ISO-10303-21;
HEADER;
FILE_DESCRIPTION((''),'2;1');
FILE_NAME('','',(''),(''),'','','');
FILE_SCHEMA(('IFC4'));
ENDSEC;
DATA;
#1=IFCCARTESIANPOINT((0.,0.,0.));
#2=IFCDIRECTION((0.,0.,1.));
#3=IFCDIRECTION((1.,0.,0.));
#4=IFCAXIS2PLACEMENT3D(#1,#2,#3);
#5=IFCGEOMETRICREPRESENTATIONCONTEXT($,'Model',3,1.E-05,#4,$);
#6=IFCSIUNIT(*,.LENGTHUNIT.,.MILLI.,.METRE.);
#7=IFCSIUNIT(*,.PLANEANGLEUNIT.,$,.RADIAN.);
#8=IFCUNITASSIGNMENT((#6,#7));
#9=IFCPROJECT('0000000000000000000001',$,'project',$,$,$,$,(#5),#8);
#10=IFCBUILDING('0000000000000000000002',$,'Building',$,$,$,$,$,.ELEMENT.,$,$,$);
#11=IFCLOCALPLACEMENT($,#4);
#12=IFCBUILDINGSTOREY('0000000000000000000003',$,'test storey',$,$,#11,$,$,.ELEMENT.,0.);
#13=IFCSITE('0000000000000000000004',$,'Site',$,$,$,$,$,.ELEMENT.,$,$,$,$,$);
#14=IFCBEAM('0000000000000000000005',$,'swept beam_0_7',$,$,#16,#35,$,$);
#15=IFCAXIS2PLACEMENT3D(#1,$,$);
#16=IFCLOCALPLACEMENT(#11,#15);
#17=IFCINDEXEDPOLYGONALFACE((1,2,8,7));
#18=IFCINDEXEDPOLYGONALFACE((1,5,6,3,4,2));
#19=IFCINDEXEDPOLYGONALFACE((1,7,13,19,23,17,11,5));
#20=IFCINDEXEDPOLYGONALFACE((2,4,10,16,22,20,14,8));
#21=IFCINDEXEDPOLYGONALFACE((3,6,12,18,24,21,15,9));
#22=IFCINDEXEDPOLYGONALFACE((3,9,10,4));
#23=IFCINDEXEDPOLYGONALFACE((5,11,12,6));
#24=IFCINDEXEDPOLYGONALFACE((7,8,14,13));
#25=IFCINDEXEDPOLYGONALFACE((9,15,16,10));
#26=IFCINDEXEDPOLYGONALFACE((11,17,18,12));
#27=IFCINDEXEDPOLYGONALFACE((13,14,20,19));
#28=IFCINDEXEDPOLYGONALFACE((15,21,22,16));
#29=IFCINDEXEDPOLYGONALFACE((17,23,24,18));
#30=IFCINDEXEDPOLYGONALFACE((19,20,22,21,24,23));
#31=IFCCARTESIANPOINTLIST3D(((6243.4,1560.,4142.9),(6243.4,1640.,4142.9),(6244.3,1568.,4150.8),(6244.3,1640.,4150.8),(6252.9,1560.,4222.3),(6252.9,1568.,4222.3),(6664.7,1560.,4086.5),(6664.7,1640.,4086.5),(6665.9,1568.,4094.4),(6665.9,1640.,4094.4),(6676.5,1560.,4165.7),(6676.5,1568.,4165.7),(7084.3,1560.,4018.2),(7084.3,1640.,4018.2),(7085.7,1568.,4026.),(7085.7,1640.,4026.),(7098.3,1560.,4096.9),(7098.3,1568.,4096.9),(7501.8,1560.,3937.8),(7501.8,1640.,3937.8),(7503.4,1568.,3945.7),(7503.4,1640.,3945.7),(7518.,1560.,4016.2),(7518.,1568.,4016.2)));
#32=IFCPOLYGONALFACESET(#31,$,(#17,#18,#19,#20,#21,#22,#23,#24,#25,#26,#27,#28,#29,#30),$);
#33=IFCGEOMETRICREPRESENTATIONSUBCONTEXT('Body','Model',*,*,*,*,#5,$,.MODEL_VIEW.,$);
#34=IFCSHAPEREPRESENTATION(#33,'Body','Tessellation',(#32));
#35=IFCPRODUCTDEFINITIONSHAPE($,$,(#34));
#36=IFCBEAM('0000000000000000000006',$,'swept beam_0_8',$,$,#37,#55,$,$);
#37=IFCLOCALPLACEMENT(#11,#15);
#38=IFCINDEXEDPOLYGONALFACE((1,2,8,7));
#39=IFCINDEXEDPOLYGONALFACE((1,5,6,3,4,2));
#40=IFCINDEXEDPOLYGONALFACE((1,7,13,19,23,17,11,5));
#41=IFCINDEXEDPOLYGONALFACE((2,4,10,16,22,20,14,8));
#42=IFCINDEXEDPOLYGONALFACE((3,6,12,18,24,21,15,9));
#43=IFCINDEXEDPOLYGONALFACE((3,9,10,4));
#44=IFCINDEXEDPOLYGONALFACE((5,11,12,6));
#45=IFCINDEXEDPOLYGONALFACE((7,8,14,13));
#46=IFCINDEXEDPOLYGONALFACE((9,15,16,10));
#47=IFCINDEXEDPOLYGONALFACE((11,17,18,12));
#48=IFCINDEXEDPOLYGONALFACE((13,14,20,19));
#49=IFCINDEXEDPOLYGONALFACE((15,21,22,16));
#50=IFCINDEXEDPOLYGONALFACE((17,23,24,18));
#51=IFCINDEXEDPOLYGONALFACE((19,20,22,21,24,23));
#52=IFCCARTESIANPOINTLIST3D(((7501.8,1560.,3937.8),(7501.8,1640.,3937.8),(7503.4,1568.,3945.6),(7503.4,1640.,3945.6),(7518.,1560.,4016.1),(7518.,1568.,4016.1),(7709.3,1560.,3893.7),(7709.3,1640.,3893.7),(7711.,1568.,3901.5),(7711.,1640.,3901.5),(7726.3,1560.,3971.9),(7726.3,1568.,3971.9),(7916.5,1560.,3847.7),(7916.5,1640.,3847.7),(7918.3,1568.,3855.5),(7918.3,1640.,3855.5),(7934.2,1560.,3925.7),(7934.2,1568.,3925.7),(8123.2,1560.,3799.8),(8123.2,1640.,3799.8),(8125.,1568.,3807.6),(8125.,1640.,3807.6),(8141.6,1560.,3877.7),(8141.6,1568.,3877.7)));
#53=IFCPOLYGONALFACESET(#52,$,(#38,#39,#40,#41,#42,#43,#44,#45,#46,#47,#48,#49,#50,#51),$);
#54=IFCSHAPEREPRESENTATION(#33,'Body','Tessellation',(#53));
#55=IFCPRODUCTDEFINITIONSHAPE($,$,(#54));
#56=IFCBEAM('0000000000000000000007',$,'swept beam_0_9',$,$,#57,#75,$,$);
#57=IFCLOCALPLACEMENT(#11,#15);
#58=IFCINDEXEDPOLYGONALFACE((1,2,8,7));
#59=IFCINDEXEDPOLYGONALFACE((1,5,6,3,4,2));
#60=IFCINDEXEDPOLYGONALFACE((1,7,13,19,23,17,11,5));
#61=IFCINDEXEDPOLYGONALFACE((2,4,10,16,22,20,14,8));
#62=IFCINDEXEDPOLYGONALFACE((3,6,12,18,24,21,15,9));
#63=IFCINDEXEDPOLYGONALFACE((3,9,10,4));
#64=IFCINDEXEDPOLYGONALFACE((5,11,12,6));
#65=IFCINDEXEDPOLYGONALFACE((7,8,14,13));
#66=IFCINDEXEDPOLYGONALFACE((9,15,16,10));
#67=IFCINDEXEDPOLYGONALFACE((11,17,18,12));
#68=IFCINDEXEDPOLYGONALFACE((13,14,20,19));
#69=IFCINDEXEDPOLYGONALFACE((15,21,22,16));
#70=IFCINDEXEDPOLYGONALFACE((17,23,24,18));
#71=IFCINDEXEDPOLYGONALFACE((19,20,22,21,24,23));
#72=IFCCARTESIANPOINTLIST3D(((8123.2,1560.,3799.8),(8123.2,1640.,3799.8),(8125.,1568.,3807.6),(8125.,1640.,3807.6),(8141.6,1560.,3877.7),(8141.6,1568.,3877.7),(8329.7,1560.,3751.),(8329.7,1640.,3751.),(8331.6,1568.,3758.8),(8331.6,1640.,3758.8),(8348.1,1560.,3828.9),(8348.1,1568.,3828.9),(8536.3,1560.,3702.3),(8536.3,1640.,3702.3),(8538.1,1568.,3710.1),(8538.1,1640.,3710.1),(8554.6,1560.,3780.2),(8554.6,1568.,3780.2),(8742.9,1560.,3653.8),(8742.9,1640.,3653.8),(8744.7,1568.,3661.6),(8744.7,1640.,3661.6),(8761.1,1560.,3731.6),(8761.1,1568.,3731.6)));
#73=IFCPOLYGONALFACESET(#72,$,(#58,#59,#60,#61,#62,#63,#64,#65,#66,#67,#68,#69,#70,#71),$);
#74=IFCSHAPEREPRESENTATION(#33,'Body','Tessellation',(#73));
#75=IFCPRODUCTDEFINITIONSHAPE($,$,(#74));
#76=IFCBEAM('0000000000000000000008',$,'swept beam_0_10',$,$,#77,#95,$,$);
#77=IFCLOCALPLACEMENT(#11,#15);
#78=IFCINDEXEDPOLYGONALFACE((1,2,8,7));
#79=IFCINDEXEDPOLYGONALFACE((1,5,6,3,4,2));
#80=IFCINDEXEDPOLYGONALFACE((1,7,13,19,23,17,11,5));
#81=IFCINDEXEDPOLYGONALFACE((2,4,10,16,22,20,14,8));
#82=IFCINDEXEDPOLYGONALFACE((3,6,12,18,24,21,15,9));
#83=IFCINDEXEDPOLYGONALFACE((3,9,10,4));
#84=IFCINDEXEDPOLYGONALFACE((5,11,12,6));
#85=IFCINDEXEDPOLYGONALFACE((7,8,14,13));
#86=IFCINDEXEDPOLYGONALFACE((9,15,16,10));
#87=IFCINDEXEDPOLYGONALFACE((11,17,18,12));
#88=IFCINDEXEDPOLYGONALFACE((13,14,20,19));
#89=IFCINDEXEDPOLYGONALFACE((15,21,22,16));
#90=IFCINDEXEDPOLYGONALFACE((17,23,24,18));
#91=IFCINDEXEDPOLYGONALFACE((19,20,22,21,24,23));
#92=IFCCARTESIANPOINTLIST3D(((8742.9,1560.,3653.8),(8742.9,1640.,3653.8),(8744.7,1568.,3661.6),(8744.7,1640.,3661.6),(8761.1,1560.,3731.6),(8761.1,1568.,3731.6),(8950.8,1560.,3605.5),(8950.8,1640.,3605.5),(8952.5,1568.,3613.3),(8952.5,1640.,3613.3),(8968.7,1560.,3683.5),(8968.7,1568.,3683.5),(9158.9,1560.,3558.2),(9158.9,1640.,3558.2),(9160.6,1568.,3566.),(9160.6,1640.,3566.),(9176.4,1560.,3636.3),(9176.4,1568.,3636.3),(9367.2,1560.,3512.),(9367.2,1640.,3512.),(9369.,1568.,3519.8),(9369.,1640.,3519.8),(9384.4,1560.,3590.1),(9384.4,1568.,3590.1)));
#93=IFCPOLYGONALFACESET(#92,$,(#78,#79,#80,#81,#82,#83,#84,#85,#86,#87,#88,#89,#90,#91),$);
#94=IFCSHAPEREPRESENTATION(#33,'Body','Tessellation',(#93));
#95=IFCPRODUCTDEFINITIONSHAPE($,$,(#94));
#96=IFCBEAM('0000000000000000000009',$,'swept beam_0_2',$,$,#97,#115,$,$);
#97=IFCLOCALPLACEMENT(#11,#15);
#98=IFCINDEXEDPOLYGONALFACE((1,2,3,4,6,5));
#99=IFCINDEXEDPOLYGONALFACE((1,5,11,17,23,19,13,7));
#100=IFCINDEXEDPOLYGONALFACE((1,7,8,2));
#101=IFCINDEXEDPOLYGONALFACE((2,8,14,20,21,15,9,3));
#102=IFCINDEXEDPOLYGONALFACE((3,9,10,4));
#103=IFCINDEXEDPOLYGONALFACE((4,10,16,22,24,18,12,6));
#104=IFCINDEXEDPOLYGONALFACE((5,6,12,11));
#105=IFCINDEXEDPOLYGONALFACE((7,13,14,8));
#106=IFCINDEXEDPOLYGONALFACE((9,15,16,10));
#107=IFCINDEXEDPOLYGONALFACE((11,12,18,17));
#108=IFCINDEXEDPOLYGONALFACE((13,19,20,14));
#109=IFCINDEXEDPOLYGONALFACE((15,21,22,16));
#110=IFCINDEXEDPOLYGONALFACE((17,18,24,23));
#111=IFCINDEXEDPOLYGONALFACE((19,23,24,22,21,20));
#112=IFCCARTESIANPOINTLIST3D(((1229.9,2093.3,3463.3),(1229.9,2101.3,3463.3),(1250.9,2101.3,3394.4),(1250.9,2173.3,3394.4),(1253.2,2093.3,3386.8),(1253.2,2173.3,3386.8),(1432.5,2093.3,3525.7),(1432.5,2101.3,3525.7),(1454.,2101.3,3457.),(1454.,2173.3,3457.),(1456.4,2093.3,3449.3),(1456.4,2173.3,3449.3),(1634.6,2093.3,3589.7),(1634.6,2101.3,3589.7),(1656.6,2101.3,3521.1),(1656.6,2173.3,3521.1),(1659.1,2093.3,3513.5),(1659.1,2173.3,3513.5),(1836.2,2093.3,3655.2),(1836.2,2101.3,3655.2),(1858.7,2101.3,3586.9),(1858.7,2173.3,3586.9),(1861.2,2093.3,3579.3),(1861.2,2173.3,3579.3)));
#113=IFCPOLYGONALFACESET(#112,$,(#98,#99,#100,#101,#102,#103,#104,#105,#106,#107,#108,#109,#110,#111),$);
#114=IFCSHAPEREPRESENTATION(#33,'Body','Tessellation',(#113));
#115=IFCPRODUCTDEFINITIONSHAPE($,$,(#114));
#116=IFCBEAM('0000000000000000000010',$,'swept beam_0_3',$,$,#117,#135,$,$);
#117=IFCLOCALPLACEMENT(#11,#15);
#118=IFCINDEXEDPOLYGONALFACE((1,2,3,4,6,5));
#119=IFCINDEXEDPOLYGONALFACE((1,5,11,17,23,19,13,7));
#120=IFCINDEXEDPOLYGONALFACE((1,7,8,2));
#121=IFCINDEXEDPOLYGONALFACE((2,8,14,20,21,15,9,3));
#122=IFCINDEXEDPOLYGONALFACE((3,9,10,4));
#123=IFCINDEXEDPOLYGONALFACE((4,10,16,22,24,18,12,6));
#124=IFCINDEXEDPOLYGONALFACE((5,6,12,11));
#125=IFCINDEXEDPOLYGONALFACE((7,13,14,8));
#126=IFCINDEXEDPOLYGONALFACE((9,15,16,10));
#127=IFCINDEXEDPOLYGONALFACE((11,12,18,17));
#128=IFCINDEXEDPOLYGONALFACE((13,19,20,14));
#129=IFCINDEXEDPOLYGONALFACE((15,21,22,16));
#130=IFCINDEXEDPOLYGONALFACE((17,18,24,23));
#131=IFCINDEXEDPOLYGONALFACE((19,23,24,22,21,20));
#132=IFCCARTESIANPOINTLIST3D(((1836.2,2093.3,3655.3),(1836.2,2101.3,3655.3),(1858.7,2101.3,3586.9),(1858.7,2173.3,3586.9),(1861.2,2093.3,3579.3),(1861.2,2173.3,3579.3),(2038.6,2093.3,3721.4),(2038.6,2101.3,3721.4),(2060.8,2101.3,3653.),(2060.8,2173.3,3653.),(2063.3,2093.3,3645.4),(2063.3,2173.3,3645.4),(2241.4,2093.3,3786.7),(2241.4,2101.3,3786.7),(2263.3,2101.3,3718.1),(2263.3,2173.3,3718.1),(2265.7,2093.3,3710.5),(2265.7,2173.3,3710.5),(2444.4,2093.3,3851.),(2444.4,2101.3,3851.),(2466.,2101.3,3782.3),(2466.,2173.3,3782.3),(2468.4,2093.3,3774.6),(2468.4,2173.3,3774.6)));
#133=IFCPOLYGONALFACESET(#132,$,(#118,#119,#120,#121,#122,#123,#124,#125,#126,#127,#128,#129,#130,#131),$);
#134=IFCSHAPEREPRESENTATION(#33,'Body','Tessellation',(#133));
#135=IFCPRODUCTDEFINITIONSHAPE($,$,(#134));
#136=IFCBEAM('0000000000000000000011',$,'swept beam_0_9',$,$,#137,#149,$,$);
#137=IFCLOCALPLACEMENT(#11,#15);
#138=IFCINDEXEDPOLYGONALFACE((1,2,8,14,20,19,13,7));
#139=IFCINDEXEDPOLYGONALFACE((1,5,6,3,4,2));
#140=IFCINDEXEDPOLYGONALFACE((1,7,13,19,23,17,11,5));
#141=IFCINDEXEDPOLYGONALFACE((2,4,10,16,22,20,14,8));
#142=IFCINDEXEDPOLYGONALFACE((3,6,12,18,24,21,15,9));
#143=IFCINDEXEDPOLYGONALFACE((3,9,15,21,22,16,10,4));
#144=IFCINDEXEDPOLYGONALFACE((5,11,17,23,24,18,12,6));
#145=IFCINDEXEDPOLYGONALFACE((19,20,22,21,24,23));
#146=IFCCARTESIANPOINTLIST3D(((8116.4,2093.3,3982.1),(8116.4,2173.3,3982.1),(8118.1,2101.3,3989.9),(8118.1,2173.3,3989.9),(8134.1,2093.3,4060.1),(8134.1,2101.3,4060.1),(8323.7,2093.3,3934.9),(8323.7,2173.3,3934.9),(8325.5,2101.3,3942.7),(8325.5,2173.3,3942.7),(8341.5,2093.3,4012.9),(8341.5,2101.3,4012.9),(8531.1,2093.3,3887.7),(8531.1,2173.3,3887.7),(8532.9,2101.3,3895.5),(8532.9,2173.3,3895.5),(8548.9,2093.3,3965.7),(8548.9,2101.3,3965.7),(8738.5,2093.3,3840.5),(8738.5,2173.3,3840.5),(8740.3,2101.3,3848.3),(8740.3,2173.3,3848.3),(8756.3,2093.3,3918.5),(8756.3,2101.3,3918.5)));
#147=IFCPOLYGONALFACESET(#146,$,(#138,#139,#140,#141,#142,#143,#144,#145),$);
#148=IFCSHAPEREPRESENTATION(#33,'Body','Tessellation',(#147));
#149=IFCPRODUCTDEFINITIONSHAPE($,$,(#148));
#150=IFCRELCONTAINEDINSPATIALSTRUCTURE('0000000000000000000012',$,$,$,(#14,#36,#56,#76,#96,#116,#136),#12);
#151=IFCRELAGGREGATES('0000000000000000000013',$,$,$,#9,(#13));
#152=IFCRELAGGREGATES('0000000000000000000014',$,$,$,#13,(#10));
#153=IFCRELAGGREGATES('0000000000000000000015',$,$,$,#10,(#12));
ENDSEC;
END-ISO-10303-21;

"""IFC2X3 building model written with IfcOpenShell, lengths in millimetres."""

from ifc_helpers import new_model, entity, si_unit, origin_with_axes, place, context, subcontext, project, spatial, element, save


model = new_model("IFC2X3")

# Units and contexts
model_context = context("Model", 3, precision=1e-05, world=origin_with_axes())
body_context = subcontext(model_context, "Body", "Model", "MODEL_VIEW")
ifc_project = project(units=[si_unit("LENGTHUNIT", "METRE", prefix="MILLI"), si_unit("PLANEANGLEUNIT", "RADIAN")], contexts=[model_context])

# Site, building, storey
site = spatial("IfcSite", under=ifc_project, Name="Site", CompositionType="ELEMENT")
building = spatial("IfcBuilding", under=site, Name="Building", CompositionType="ELEMENT")
storey_placement = place(None, origin_with_axes())
storey = spatial("IfcBuildingStorey", under=building, at=storey_placement, Name="test storey", CompositionType="ELEMENT", Elevation=0.0)

# Beams
beam_1_placement = place(storey_placement, origin_with_axes())
element("IfcBeam", 1, at=beam_1_placement, inside=storey, Name="swept beam_0_7", context=body_context, shape_type="SweptSolid", body=[
    entity("IfcRevolvedAreaSolid", entity("IfcArbitraryClosedProfileDef", "AREA", None, entity("IfcPolyline", [entity("IfcCartesianPoint", [80.0, -40.0]), entity("IfcCartesianPoint", [80.0, -32.0]), entity("IfcCartesianPoint", [8.0, -32.0]), entity("IfcCartesianPoint", [8.0, 40.0]), entity("IfcCartesianPoint", [0.0, 40.0]), entity("IfcCartesianPoint", [0.0, -40.0]), entity("IfcCartesianPoint", [80.0, -40.0])])), entity("IfcAxis2Placement3D", entity("IfcCartesianPoint", [6243.4, 1600.0, 4142.9]), entity("IfcDirection", [-0.993, 0.0, 0.1183]), entity("IfcDirection", [0.1183, 0.0, 0.993])), entity("IfcAxis1Placement", entity("IfcCartesianPoint", [-14849.0, 0.0, 0.0]), entity("IfcDirection", [0.0, 1.0, 0.0])), 0.085889),
])
beam_2_placement = place(storey_placement, origin_with_axes())
element("IfcBeam", 2, at=beam_2_placement, inside=storey, Name="swept beam_0_8", context=body_context, shape_type="SweptSolid", body=[
    entity("IfcRevolvedAreaSolid", entity("IfcArbitraryClosedProfileDef", "AREA", None, entity("IfcPolyline", [entity("IfcCartesianPoint", [80.0, -40.0]), entity("IfcCartesianPoint", [80.0, -32.0]), entity("IfcCartesianPoint", [8.0, -32.0]), entity("IfcCartesianPoint", [8.0, 40.0]), entity("IfcCartesianPoint", [0.0, 40.0]), entity("IfcCartesianPoint", [0.0, -40.0]), entity("IfcCartesianPoint", [80.0, -40.0])])), entity("IfcAxis2Placement3D", entity("IfcCartesianPoint", [7501.8, 1600.0, 3937.8]), entity("IfcDirection", [-0.9792, 0.0, 0.2031]), entity("IfcDirection", [0.2031, 0.0, 0.9792])), entity("IfcAxis1Placement", entity("IfcCartesianPoint", [-22828.3, 0.0, 0.0]), entity("IfcDirection", [0.0, 1.0, 0.0])), 0.027886),
])
beam_3_placement = place(storey_placement, origin_with_axes())
element("IfcBeam", 3, at=beam_3_placement, inside=storey, Name="swept beam_0_9", context=body_context, shape_type="SweptSolid", body=[
    entity("IfcRevolvedAreaSolid", entity("IfcArbitraryClosedProfileDef", "AREA", None, entity("IfcPolyline", [entity("IfcCartesianPoint", [-80.0, 40.0]), entity("IfcCartesianPoint", [-80.0, 32.0]), entity("IfcCartesianPoint", [-8.0, 32.0]), entity("IfcCartesianPoint", [-8.0, -40.0]), entity("IfcCartesianPoint", [0.0, -40.0]), entity("IfcCartesianPoint", [0.0, 40.0]), entity("IfcCartesianPoint", [-80.0, 40.0])])), entity("IfcAxis2Placement3D", entity("IfcCartesianPoint", [8123.2, 1600.0, 3799.8]), entity("IfcDirection", [-0.9731, 0.0, 0.2303]), entity("IfcDirection", [-0.2303, 0.0, -0.9731])), entity("IfcAxis1Placement", entity("IfcCartesianPoint", [-346113.7, 0.0, 0.0]), entity("IfcDirection", [0.0, 1.0, 0.0])), 0.001839),
])
beam_4_placement = place(storey_placement, origin_with_axes())
element("IfcBeam", 4, at=beam_4_placement, inside=storey, Name="swept beam_0_10", context=body_context, shape_type="SweptSolid", body=[
    entity("IfcRevolvedAreaSolid", entity("IfcArbitraryClosedProfileDef", "AREA", None, entity("IfcPolyline", [entity("IfcCartesianPoint", [-80.0, 40.0]), entity("IfcCartesianPoint", [-80.0, 32.0]), entity("IfcCartesianPoint", [-8.0, 32.0]), entity("IfcCartesianPoint", [-8.0, -40.0]), entity("IfcCartesianPoint", [0.0, -40.0]), entity("IfcCartesianPoint", [0.0, 40.0]), entity("IfcCartesianPoint", [-80.0, 40.0])])), entity("IfcAxis2Placement3D", entity("IfcCartesianPoint", [8742.9, 1600.0, 3653.8]), entity("IfcDirection", [-0.9735, 0.0, 0.2285]), entity("IfcDirection", [-0.2285, 0.0, -0.9735])), entity("IfcAxis1Placement", entity("IfcCartesianPoint", [-44317.9, 0.0, 0.0]), entity("IfcDirection", [0.0, 1.0, 0.0])), 0.014448),
])
beam_5_placement = place(storey_placement, origin_with_axes())
element("IfcBeam", 5, at=beam_5_placement, inside=storey, Name="swept beam_0_2", context=body_context, shape_type="SweptSolid", body=[
    entity("IfcRevolvedAreaSolid", entity("IfcArbitraryClosedProfileDef", "AREA", None, entity("IfcPolyline", [entity("IfcCartesianPoint", [-80.0, 40.0]), entity("IfcCartesianPoint", [-80.0, 32.0]), entity("IfcCartesianPoint", [-8.0, 32.0]), entity("IfcCartesianPoint", [-8.0, -40.0]), entity("IfcCartesianPoint", [0.0, -40.0]), entity("IfcCartesianPoint", [0.0, 40.0]), entity("IfcCartesianPoint", [-80.0, 40.0])])), entity("IfcAxis2Placement3D", entity("IfcCartesianPoint", [1253.2, 2133.3, 3386.8]), entity("IfcDirection", [-0.9568, 0.0, -0.2906]), entity("IfcDirection", [0.2906, 0.0, -0.9568])), entity("IfcAxis1Placement", entity("IfcCartesianPoint", [-27170.3, 0.0, 0.0]), entity("IfcDirection", [0.0, 1.0, 0.0])), 0.023474),
])
beam_6_placement = place(storey_placement, origin_with_axes())
element("IfcBeam", 6, at=beam_6_placement, inside=storey, Name="swept beam_0_3", context=body_context, shape_type="SweptSolid", body=[
    entity("IfcRevolvedAreaSolid", entity("IfcArbitraryClosedProfileDef", "AREA", None, entity("IfcPolyline", [entity("IfcCartesianPoint", [80.0, -40.0]), entity("IfcCartesianPoint", [80.0, -32.0]), entity("IfcCartesianPoint", [8.0, -32.0]), entity("IfcCartesianPoint", [8.0, 40.0]), entity("IfcCartesianPoint", [0.0, 40.0]), entity("IfcCartesianPoint", [0.0, -40.0]), entity("IfcCartesianPoint", [80.0, -40.0])])), entity("IfcAxis2Placement3D", entity("IfcCartesianPoint", [1861.2, 2133.3, 3579.3]), entity("IfcDirection", [-0.9497, 0.0, -0.313]), entity("IfcDirection", [-0.313, 0.0, 0.9497])), entity("IfcAxis1Placement", entity("IfcCartesianPoint", [-44978.1, 0.0, 0.0]), entity("IfcDirection", [0.0, 1.0, 0.0])), 0.014181),
])
beam_7_placement = place(storey_placement, origin_with_axes())
element("IfcBeam", 7, at=beam_7_placement, inside=storey, Name="swept beam_0_9", context=body_context, shape_type="SweptSolid", body=[
    entity("IfcRevolvedAreaSolid", entity("IfcArbitraryClosedProfileDef", "AREA", None, entity("IfcPolyline", [entity("IfcCartesianPoint", [-80.0, 40.0]), entity("IfcCartesianPoint", [-80.0, 32.0]), entity("IfcCartesianPoint", [-8.0, 32.0]), entity("IfcCartesianPoint", [-8.0, -40.0]), entity("IfcCartesianPoint", [0.0, -40.0]), entity("IfcCartesianPoint", [0.0, 40.0]), entity("IfcCartesianPoint", [-80.0, 40.0])])), entity("IfcAxis2Placement3D", entity("IfcCartesianPoint", [8116.4, 2133.3, 3982.1]), entity("IfcDirection", [-0.975, 0.0, 0.2221]), entity("IfcDirection", [-0.2221, 0.0, -0.975])), entity("IfcAxis1Placement", entity("IfcCartesianPoint", [-1395153.4, 0.0, 0.0]), entity("IfcDirection", [0.0, 1.0, 0.0])), 0.000457),
])

save(model, "model.ifc")
